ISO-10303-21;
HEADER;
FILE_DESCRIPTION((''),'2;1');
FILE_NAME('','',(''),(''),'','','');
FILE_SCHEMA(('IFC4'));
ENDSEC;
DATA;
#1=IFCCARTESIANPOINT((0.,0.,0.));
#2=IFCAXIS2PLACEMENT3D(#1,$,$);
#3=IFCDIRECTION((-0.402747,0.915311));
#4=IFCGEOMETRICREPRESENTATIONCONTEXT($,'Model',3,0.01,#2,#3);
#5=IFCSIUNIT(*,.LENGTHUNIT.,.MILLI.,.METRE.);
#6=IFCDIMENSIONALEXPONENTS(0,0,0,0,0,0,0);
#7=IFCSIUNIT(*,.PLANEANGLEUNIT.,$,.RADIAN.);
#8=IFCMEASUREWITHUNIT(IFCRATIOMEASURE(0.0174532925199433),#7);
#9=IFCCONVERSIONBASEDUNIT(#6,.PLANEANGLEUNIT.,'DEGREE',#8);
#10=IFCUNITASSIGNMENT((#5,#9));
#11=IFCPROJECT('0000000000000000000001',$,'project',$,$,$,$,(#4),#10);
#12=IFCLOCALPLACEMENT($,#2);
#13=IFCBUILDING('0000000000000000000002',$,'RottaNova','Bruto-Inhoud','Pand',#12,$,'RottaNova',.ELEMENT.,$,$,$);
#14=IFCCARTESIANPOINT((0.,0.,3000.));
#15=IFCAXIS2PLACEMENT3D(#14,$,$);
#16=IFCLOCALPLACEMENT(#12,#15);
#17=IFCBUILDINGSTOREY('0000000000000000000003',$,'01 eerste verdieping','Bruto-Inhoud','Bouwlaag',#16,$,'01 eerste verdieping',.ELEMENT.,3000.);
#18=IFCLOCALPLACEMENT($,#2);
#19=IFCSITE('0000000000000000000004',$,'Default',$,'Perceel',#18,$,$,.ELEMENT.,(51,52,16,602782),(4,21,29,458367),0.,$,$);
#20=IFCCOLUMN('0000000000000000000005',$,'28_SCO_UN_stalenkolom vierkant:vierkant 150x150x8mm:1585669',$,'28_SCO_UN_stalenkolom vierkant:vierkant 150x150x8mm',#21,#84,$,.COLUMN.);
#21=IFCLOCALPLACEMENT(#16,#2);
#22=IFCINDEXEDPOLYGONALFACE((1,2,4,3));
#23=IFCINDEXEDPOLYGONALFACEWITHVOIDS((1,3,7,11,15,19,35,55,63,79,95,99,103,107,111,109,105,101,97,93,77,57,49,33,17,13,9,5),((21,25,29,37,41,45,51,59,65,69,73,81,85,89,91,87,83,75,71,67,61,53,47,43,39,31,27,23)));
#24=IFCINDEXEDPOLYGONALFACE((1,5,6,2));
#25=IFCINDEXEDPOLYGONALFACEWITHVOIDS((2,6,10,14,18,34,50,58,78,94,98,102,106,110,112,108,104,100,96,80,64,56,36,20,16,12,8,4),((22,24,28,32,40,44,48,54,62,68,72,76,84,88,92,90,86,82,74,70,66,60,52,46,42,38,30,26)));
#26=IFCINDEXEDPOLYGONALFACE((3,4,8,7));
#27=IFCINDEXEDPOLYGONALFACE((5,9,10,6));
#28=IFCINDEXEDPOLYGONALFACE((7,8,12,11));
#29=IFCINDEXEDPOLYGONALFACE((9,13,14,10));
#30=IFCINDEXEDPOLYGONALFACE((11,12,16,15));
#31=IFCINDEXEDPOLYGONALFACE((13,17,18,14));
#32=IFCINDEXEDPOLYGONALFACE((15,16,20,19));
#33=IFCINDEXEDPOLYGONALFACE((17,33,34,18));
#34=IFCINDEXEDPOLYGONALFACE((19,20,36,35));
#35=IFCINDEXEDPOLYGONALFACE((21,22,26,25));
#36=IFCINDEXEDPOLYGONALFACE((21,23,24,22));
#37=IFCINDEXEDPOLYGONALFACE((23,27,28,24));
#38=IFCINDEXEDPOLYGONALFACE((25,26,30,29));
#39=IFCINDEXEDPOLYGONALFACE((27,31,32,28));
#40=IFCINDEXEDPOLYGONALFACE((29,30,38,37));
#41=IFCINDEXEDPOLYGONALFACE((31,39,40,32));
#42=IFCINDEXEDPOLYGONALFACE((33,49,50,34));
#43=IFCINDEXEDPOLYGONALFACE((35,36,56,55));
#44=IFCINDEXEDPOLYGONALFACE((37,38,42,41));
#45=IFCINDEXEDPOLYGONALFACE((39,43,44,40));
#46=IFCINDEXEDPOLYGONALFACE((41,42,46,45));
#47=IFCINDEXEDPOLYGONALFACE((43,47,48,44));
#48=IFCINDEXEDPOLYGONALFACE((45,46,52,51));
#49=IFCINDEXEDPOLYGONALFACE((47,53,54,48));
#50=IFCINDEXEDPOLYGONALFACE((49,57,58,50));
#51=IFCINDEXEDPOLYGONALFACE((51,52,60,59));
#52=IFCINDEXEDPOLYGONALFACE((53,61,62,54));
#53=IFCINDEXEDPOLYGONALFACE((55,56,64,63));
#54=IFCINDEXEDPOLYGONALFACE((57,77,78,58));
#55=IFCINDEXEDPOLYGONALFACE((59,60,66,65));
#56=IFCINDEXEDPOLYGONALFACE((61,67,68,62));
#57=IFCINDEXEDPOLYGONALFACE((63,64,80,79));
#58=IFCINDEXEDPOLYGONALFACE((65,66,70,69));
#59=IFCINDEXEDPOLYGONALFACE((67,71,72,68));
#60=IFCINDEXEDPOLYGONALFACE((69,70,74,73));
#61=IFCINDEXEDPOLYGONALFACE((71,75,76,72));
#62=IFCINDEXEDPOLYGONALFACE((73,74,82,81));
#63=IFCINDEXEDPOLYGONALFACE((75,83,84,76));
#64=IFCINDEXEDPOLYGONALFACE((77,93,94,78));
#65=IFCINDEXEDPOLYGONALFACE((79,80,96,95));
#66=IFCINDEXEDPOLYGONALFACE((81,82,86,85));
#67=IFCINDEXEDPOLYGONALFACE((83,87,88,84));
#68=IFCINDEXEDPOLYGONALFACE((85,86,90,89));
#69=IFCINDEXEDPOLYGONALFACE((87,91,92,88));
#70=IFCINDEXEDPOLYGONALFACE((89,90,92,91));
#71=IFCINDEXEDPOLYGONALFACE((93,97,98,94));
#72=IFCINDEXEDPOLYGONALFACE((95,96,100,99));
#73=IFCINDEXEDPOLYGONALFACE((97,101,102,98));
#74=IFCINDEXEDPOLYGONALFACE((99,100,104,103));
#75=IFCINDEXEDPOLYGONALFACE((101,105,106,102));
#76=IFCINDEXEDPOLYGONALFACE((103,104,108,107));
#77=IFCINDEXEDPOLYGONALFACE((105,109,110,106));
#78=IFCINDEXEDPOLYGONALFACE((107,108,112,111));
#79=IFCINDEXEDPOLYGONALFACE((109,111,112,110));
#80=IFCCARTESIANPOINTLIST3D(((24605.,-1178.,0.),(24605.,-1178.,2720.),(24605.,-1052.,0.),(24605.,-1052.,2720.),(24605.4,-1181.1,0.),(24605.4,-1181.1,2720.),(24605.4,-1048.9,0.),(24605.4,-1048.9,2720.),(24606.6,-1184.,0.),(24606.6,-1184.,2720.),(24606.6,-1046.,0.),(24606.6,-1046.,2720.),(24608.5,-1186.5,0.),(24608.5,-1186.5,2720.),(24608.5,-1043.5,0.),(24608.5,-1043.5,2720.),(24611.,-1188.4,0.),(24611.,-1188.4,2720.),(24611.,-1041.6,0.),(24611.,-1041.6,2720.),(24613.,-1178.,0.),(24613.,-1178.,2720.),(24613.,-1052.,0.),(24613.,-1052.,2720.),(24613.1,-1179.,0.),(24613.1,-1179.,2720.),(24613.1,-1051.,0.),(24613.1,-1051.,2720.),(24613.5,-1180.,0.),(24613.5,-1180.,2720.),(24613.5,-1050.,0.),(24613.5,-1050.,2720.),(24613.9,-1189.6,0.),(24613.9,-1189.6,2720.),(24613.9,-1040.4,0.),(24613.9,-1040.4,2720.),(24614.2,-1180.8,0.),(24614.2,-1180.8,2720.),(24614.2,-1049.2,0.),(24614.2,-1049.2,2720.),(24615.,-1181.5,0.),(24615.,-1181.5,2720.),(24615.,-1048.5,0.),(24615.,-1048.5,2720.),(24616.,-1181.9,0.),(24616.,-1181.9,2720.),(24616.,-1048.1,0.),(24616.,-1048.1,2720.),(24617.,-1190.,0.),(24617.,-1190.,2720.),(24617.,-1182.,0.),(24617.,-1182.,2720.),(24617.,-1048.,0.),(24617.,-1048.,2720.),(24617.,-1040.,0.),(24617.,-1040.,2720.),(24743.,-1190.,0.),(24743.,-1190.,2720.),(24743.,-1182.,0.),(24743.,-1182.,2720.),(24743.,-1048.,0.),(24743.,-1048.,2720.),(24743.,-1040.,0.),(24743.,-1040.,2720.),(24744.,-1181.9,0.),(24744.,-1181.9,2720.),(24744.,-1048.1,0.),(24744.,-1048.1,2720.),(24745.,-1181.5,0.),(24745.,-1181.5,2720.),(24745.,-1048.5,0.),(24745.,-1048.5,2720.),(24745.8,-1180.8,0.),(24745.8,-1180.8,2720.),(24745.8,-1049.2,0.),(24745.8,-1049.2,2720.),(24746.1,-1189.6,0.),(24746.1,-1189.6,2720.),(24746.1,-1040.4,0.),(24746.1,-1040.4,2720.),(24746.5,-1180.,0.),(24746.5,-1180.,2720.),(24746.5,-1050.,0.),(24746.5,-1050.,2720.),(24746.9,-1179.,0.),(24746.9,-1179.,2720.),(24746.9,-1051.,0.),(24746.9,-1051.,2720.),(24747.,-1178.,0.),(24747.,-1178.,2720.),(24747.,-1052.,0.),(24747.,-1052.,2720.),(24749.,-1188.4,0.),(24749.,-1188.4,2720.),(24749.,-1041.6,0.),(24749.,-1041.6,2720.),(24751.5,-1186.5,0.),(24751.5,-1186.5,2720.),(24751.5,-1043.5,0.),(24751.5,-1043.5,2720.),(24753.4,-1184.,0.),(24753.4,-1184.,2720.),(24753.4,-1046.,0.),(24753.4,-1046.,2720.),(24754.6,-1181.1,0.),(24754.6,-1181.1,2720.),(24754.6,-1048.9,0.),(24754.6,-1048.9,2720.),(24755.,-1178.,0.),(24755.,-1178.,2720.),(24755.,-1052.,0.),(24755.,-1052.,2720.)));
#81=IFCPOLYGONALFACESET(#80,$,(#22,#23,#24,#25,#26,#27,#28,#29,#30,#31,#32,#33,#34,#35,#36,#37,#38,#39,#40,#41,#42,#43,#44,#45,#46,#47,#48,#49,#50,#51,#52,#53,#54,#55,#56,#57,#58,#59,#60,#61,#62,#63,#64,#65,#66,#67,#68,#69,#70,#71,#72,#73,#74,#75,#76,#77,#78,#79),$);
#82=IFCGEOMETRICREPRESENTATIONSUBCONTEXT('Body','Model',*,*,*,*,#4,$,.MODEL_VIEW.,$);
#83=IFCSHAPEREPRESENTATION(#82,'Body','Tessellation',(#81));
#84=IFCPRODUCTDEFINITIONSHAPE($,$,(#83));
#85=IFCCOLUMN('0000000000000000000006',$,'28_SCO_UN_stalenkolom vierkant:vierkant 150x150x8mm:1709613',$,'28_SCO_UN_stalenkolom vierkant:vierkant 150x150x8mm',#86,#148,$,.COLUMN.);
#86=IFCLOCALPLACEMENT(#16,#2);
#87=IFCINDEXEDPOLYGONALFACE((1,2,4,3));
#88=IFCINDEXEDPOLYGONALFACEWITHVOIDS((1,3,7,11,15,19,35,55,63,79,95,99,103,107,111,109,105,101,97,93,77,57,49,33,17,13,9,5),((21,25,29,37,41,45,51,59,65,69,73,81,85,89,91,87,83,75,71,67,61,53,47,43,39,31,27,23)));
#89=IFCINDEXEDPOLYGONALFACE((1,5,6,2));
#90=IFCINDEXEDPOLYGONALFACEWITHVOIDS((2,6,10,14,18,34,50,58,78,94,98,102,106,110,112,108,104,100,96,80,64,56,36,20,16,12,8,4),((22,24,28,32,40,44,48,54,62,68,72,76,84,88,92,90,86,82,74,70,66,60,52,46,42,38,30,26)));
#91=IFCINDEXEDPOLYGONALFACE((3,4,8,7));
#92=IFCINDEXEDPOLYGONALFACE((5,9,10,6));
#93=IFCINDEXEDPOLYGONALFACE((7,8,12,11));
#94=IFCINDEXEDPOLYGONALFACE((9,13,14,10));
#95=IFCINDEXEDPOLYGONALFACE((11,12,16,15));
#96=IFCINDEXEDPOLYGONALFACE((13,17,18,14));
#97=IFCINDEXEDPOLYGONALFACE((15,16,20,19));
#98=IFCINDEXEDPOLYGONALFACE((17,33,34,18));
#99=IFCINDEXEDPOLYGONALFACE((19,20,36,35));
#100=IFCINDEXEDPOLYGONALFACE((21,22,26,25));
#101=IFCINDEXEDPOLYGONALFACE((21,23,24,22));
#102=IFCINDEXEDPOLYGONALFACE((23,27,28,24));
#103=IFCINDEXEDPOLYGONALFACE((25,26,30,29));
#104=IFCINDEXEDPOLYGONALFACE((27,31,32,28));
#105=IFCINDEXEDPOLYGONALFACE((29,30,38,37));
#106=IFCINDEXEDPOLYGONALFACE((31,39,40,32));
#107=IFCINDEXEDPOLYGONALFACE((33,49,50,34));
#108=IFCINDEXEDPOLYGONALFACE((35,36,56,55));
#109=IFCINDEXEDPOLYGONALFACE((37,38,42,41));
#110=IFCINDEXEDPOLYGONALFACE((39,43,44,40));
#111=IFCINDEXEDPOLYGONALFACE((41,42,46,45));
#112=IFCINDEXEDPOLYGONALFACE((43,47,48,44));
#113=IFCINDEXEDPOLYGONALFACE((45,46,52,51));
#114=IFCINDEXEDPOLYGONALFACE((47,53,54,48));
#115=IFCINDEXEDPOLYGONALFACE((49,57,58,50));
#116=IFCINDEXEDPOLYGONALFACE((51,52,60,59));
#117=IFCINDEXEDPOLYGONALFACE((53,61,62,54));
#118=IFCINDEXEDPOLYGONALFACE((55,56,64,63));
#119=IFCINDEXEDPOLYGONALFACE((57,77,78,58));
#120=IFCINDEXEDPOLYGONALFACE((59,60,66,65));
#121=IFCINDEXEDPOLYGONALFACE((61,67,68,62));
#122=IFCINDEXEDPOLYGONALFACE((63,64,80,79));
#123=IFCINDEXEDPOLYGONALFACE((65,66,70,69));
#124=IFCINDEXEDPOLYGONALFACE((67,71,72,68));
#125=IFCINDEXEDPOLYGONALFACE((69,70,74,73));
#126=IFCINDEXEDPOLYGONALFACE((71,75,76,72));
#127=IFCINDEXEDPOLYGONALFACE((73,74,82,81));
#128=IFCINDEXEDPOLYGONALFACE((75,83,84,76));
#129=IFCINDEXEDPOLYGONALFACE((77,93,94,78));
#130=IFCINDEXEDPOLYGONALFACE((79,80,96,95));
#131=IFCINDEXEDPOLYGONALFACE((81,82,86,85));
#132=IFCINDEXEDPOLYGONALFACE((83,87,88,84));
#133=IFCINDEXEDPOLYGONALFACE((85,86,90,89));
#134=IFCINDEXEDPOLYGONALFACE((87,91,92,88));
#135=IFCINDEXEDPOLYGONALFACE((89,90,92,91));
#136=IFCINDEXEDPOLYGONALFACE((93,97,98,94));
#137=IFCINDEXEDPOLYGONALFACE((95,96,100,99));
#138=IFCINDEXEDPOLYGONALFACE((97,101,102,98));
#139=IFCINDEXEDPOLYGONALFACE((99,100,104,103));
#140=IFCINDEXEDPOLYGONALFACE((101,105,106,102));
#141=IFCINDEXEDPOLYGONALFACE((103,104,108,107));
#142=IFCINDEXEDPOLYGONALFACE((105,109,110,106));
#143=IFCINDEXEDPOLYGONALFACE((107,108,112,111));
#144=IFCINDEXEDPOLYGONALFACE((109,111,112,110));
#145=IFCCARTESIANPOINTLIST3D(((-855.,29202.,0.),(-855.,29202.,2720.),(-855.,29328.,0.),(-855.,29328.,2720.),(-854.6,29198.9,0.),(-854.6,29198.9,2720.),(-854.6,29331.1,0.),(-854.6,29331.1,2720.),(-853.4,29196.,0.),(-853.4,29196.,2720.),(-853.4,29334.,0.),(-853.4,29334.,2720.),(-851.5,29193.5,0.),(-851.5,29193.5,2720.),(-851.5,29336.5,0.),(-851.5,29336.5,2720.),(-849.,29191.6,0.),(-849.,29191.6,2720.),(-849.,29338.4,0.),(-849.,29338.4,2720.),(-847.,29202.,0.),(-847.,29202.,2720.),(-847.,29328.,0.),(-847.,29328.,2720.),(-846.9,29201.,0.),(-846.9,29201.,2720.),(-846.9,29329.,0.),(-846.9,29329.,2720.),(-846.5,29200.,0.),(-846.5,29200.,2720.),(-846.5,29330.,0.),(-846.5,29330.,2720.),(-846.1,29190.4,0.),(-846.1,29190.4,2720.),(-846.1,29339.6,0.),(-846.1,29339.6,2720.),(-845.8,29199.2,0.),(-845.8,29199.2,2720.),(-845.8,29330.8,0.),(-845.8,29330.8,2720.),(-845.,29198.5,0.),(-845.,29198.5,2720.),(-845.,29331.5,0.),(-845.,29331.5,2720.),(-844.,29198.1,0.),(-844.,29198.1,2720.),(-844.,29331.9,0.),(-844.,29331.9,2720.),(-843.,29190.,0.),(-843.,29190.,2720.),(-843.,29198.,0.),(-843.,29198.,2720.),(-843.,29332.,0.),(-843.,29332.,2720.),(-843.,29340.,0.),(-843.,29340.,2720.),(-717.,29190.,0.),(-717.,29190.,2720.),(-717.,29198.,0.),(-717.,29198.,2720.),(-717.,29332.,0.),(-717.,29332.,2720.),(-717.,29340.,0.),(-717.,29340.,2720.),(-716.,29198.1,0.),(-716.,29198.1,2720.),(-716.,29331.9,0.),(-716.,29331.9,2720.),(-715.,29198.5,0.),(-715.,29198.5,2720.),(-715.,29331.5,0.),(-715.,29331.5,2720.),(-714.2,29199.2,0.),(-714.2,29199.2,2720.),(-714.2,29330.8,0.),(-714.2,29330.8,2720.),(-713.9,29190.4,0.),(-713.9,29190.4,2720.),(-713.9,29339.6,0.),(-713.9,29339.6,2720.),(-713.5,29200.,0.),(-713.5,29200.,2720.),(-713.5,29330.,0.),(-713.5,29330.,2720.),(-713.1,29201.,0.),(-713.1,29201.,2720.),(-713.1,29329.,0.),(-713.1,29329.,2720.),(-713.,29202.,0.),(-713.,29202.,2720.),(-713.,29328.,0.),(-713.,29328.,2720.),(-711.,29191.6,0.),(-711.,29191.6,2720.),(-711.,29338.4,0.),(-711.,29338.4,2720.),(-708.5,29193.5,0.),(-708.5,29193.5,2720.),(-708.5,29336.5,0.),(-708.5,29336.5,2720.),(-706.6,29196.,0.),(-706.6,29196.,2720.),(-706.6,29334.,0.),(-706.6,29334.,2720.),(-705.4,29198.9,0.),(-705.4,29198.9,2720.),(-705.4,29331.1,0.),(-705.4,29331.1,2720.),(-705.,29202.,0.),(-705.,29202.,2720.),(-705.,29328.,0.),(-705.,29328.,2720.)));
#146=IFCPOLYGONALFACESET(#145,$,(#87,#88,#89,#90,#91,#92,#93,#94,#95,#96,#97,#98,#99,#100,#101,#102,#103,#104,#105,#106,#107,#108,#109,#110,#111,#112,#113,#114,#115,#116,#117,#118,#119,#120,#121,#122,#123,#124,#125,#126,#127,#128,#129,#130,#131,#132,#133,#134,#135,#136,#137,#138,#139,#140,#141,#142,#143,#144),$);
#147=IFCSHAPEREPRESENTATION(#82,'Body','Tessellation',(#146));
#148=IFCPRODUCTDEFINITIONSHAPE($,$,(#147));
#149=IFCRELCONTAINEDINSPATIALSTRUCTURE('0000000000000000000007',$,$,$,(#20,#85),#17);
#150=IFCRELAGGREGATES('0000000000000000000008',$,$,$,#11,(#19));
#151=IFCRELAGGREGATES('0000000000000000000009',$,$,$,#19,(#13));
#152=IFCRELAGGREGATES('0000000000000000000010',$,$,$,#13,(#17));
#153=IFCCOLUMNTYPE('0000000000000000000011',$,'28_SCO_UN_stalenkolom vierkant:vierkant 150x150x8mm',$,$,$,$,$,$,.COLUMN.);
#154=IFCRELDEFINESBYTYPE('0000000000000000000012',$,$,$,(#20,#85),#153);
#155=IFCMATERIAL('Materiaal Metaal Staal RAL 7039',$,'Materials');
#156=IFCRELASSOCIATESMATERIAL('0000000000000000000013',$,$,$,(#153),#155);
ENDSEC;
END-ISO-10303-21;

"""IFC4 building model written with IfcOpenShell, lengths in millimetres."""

from ifc_helpers import new_model, entity, si_unit, converted_unit, direction, frame, frame_2d, origin, place, context, subcontext, project, spatial, polyline, circle_curve, parameter, trimmed, segment, composite_curve, outline, extrude, source, transform, mapped, material, material_profile, profile_set, type_object, type_shapes, element, save


model = new_model("IFC4")

# Units and contexts
model_context = context("Model", 3, precision=0.01, world=origin(), true_north=direction((-0.402747, 0.915311)))
body_context = subcontext(model_context, "Body", "Model", "MODEL_VIEW")
ifc_project = project(units=[si_unit("LENGTHUNIT", "METRE", prefix="MILLI"), converted_unit("PLANEANGLEUNIT", "DEGREE", entity("IfcRatioMeasure", 0.0174532925199433), si_unit("PLANEANGLEUNIT", "RADIAN"), dimensions=[0, 0, 0, 0, 0, 0, 0])], contexts=[model_context])

# Site, building, storey
site_placement = place(None, origin())
site = spatial("IfcSite", under=ifc_project, at=site_placement, Name="Default", ObjectType="Perceel", CompositionType="ELEMENT", RefLatitude=(51, 52, 16, 602782), RefLongitude=(4, 21, 29, 458367), RefElevation=0.0)
building_placement = place(None, origin())
building = spatial("IfcBuilding", under=site, at=building_placement, Name="RottaNova", Description="Bruto-Inhoud", ObjectType="Pand", LongName="RottaNova", CompositionType="ELEMENT")
storey_placement = place(building_placement, frame((0.0, 0.0, 3000.0)))
storey = spatial("IfcBuildingStorey", under=building, at=storey_placement, Name="01 eerste verdieping", Description="Bruto-Inhoud", ObjectType="Bouwlaag", LongName="01 eerste verdieping", CompositionType="ELEMENT", Elevation=3000.0)

# Columns
ifc_material_1 = material(Name="Materiaal Metaal Staal RAL 7039", Category="Materials")
ifc_material_profile = material_profile(ifc_material_1, outline(composite_curve([segment(trimmed(circle_curve(frame_2d((63.0, -63.0), x_axis=(1.0, 0.0)), 12.0), [parameter(270.0)], [parameter(360.0)], True, "PARAMETER"), True, "CONTINUOUS"), segment(polyline([(75.0, -63.0), (75.0, 63.0)]), True, "CONTINUOUS"), segment(trimmed(circle_curve(frame_2d((63.0, 63.0), x_axis=(1.0, 0.0)), 12.0), [parameter(360.0)], [parameter(90.0)], True, "PARAMETER"), True, "CONTINUOUS"), segment(polyline([(63.0, 75.0), (-63.0, 75.0)]), True, "CONTINUOUS"), segment(trimmed(circle_curve(frame_2d((-63.0, 63.0), x_axis=(1.0, 0.0)), 12.0), [parameter(90.0)], [parameter(180.0)], True, "PARAMETER"), True, "CONTINUOUS"), segment(polyline([(-75.0, 63.0), (-75.0, -63.0)]), True, "CONTINUOUS"), segment(trimmed(circle_curve(frame_2d((-63.0, -63.0), x_axis=(1.0, 0.0)), 12.0), [parameter(180.0)], [parameter(270.0)], True, "PARAMETER"), True, "CONTINUOUS"), segment(polyline([(-63.0, -75.0), (63.0, -75.0)]), True, "CONTINUOUS")], self_intersect=False), holes=[composite_curve([segment(polyline([(-67.0, -63.0), (-67.0, 63.0)]), True, "CONTINUOUS"), segment(trimmed(circle_curve(frame_2d((-63.0, 63.0), x_axis=(1.0, 0.0)), 4.0), [parameter(90.0)], [parameter(180.0)], True, "PARAMETER"), False, "CONTINUOUS"), segment(polyline([(-63.0, 67.0), (63.0, 67.0)]), True, "CONTINUOUS"), segment(trimmed(circle_curve(frame_2d((63.0, 63.0), x_axis=(1.0, 0.0)), 4.0), [parameter(0.0)], [parameter(90.0)], True, "PARAMETER"), False, "CONTINUOUS"), segment(polyline([(67.0, 63.0), (67.0, -63.0)]), True, "CONTINUOUS"), segment(trimmed(circle_curve(frame_2d((63.0, -63.0), x_axis=(1.0, 0.0)), 4.0), [parameter(270.0)], [parameter(0.0)], True, "PARAMETER"), False, "CONTINUOUS"), segment(polyline([(63.0, -67.0), (-63.0, -67.0)]), True, "CONTINUOUS"), segment(trimmed(circle_curve(frame_2d((-63.0, -63.0), x_axis=(1.0, 0.0)), 4.0), [parameter(180.0)], [parameter(270.0)], True, "PARAMETER"), False, "CONTINUOUS")], self_intersect=False)]), Name="vierkant 150x150x8mm")
ifc_profile_set = profile_set([ifc_material_profile], Name="vierkant 150x150x8mm")
column_type_1 = type_object("IfcColumnType", Name="28_SCO_UN_stalenkolom vierkant:vierkant 150x150x8mm", PredefinedType="COLUMN", material=ifc_profile_set)
shared_shape_1 = source(origin(), body_context, "Body", "SweptSolid", [
    extrude(outline(composite_curve([segment(trimmed(circle_curve(frame_2d((63.0, -63.0), x_axis=(1.0, 0.0)), 12.0), [parameter(270.0)], [parameter(360.0)], True, "PARAMETER"), True, "CONTINUOUS"), segment(polyline([(75.0, -63.0), (75.0, 63.0)]), True, "CONTINUOUS"), segment(trimmed(circle_curve(frame_2d((63.0, 63.0), x_axis=(1.0, 0.0)), 12.0), [parameter(360.0)], [parameter(90.0)], True, "PARAMETER"), True, "CONTINUOUS"), segment(polyline([(63.0, 75.0), (-63.0, 75.0)]), True, "CONTINUOUS"), segment(trimmed(circle_curve(frame_2d((-63.0, 63.0), x_axis=(1.0, 0.0)), 12.0), [parameter(90.0)], [parameter(180.0)], True, "PARAMETER"), True, "CONTINUOUS"), segment(polyline([(-75.0, 63.0), (-75.0, -63.0)]), True, "CONTINUOUS"), segment(trimmed(circle_curve(frame_2d((-63.0, -63.0), x_axis=(1.0, 0.0)), 12.0), [parameter(180.0)], [parameter(270.0)], True, "PARAMETER"), True, "CONTINUOUS"), segment(polyline([(-63.0, -75.0), (63.0, -75.0)]), True, "CONTINUOUS")], self_intersect=False), holes=[composite_curve([segment(polyline([(-67.0, -63.0), (-67.0, 63.0)]), True, "CONTINUOUS"), segment(trimmed(circle_curve(frame_2d((-63.0, 63.0), x_axis=(1.0, 0.0)), 4.0), [parameter(90.0)], [parameter(180.0)], True, "PARAMETER"), False, "CONTINUOUS"), segment(polyline([(-63.0, 67.0), (63.0, 67.0)]), True, "CONTINUOUS"), segment(trimmed(circle_curve(frame_2d((63.0, 63.0), x_axis=(1.0, 0.0)), 4.0), [parameter(0.0)], [parameter(90.0)], True, "PARAMETER"), False, "CONTINUOUS"), segment(polyline([(67.0, 63.0), (67.0, -63.0)]), True, "CONTINUOUS"), segment(trimmed(circle_curve(frame_2d((63.0, -63.0), x_axis=(1.0, 0.0)), 4.0), [parameter(270.0)], [parameter(0.0)], True, "PARAMETER"), False, "CONTINUOUS"), segment(polyline([(63.0, -67.0), (-63.0, -67.0)]), True, "CONTINUOUS"), segment(trimmed(circle_curve(frame_2d((-63.0, -63.0), x_axis=(1.0, 0.0)), 4.0), [parameter(180.0)], [parameter(270.0)], True, "PARAMETER"), False, "CONTINUOUS")], self_intersect=False)]), frame((76.6, 76.6, 0.0)), (0.0, 0.0, 1.0), 2720.0),
])
type_shapes(column_type_1, [shared_shape_1])
column_1_placement = place(storey_placement, frame((24603.4, -1191.6, 0.0)))
element("IfcColumn", 1, at=column_1_placement, inside=storey, type_object=column_type_1, Name="28_SCO_UN_stalenkolom vierkant:vierkant 150x150x8mm:1585669", ObjectType="28_SCO_UN_stalenkolom vierkant:vierkant 150x150x8mm", PredefinedType="COLUMN", context=body_context, shape_type="MappedRepresentation", body=[
    mapped(shared_shape_1, transform((0.0, 0.0, 0.0), scale=1.0)),
])
column_2_placement = place(storey_placement, frame((-703.4, 29341.6, 0.0), z_axis=(0.0, 0.0, 1.0), x_axis=(-1.0, 0.0, 0.0)))
element("IfcColumn", 2, at=column_2_placement, inside=storey, type_object=column_type_1, Name="28_SCO_UN_stalenkolom vierkant:vierkant 150x150x8mm:1709613", ObjectType="28_SCO_UN_stalenkolom vierkant:vierkant 150x150x8mm", PredefinedType="COLUMN", context=body_context, shape_type="MappedRepresentation", body=[
    mapped(shared_shape_1, transform((0.0, 0.0, 0.0), scale=1.0)),
])

save(model, "model.ifc")
